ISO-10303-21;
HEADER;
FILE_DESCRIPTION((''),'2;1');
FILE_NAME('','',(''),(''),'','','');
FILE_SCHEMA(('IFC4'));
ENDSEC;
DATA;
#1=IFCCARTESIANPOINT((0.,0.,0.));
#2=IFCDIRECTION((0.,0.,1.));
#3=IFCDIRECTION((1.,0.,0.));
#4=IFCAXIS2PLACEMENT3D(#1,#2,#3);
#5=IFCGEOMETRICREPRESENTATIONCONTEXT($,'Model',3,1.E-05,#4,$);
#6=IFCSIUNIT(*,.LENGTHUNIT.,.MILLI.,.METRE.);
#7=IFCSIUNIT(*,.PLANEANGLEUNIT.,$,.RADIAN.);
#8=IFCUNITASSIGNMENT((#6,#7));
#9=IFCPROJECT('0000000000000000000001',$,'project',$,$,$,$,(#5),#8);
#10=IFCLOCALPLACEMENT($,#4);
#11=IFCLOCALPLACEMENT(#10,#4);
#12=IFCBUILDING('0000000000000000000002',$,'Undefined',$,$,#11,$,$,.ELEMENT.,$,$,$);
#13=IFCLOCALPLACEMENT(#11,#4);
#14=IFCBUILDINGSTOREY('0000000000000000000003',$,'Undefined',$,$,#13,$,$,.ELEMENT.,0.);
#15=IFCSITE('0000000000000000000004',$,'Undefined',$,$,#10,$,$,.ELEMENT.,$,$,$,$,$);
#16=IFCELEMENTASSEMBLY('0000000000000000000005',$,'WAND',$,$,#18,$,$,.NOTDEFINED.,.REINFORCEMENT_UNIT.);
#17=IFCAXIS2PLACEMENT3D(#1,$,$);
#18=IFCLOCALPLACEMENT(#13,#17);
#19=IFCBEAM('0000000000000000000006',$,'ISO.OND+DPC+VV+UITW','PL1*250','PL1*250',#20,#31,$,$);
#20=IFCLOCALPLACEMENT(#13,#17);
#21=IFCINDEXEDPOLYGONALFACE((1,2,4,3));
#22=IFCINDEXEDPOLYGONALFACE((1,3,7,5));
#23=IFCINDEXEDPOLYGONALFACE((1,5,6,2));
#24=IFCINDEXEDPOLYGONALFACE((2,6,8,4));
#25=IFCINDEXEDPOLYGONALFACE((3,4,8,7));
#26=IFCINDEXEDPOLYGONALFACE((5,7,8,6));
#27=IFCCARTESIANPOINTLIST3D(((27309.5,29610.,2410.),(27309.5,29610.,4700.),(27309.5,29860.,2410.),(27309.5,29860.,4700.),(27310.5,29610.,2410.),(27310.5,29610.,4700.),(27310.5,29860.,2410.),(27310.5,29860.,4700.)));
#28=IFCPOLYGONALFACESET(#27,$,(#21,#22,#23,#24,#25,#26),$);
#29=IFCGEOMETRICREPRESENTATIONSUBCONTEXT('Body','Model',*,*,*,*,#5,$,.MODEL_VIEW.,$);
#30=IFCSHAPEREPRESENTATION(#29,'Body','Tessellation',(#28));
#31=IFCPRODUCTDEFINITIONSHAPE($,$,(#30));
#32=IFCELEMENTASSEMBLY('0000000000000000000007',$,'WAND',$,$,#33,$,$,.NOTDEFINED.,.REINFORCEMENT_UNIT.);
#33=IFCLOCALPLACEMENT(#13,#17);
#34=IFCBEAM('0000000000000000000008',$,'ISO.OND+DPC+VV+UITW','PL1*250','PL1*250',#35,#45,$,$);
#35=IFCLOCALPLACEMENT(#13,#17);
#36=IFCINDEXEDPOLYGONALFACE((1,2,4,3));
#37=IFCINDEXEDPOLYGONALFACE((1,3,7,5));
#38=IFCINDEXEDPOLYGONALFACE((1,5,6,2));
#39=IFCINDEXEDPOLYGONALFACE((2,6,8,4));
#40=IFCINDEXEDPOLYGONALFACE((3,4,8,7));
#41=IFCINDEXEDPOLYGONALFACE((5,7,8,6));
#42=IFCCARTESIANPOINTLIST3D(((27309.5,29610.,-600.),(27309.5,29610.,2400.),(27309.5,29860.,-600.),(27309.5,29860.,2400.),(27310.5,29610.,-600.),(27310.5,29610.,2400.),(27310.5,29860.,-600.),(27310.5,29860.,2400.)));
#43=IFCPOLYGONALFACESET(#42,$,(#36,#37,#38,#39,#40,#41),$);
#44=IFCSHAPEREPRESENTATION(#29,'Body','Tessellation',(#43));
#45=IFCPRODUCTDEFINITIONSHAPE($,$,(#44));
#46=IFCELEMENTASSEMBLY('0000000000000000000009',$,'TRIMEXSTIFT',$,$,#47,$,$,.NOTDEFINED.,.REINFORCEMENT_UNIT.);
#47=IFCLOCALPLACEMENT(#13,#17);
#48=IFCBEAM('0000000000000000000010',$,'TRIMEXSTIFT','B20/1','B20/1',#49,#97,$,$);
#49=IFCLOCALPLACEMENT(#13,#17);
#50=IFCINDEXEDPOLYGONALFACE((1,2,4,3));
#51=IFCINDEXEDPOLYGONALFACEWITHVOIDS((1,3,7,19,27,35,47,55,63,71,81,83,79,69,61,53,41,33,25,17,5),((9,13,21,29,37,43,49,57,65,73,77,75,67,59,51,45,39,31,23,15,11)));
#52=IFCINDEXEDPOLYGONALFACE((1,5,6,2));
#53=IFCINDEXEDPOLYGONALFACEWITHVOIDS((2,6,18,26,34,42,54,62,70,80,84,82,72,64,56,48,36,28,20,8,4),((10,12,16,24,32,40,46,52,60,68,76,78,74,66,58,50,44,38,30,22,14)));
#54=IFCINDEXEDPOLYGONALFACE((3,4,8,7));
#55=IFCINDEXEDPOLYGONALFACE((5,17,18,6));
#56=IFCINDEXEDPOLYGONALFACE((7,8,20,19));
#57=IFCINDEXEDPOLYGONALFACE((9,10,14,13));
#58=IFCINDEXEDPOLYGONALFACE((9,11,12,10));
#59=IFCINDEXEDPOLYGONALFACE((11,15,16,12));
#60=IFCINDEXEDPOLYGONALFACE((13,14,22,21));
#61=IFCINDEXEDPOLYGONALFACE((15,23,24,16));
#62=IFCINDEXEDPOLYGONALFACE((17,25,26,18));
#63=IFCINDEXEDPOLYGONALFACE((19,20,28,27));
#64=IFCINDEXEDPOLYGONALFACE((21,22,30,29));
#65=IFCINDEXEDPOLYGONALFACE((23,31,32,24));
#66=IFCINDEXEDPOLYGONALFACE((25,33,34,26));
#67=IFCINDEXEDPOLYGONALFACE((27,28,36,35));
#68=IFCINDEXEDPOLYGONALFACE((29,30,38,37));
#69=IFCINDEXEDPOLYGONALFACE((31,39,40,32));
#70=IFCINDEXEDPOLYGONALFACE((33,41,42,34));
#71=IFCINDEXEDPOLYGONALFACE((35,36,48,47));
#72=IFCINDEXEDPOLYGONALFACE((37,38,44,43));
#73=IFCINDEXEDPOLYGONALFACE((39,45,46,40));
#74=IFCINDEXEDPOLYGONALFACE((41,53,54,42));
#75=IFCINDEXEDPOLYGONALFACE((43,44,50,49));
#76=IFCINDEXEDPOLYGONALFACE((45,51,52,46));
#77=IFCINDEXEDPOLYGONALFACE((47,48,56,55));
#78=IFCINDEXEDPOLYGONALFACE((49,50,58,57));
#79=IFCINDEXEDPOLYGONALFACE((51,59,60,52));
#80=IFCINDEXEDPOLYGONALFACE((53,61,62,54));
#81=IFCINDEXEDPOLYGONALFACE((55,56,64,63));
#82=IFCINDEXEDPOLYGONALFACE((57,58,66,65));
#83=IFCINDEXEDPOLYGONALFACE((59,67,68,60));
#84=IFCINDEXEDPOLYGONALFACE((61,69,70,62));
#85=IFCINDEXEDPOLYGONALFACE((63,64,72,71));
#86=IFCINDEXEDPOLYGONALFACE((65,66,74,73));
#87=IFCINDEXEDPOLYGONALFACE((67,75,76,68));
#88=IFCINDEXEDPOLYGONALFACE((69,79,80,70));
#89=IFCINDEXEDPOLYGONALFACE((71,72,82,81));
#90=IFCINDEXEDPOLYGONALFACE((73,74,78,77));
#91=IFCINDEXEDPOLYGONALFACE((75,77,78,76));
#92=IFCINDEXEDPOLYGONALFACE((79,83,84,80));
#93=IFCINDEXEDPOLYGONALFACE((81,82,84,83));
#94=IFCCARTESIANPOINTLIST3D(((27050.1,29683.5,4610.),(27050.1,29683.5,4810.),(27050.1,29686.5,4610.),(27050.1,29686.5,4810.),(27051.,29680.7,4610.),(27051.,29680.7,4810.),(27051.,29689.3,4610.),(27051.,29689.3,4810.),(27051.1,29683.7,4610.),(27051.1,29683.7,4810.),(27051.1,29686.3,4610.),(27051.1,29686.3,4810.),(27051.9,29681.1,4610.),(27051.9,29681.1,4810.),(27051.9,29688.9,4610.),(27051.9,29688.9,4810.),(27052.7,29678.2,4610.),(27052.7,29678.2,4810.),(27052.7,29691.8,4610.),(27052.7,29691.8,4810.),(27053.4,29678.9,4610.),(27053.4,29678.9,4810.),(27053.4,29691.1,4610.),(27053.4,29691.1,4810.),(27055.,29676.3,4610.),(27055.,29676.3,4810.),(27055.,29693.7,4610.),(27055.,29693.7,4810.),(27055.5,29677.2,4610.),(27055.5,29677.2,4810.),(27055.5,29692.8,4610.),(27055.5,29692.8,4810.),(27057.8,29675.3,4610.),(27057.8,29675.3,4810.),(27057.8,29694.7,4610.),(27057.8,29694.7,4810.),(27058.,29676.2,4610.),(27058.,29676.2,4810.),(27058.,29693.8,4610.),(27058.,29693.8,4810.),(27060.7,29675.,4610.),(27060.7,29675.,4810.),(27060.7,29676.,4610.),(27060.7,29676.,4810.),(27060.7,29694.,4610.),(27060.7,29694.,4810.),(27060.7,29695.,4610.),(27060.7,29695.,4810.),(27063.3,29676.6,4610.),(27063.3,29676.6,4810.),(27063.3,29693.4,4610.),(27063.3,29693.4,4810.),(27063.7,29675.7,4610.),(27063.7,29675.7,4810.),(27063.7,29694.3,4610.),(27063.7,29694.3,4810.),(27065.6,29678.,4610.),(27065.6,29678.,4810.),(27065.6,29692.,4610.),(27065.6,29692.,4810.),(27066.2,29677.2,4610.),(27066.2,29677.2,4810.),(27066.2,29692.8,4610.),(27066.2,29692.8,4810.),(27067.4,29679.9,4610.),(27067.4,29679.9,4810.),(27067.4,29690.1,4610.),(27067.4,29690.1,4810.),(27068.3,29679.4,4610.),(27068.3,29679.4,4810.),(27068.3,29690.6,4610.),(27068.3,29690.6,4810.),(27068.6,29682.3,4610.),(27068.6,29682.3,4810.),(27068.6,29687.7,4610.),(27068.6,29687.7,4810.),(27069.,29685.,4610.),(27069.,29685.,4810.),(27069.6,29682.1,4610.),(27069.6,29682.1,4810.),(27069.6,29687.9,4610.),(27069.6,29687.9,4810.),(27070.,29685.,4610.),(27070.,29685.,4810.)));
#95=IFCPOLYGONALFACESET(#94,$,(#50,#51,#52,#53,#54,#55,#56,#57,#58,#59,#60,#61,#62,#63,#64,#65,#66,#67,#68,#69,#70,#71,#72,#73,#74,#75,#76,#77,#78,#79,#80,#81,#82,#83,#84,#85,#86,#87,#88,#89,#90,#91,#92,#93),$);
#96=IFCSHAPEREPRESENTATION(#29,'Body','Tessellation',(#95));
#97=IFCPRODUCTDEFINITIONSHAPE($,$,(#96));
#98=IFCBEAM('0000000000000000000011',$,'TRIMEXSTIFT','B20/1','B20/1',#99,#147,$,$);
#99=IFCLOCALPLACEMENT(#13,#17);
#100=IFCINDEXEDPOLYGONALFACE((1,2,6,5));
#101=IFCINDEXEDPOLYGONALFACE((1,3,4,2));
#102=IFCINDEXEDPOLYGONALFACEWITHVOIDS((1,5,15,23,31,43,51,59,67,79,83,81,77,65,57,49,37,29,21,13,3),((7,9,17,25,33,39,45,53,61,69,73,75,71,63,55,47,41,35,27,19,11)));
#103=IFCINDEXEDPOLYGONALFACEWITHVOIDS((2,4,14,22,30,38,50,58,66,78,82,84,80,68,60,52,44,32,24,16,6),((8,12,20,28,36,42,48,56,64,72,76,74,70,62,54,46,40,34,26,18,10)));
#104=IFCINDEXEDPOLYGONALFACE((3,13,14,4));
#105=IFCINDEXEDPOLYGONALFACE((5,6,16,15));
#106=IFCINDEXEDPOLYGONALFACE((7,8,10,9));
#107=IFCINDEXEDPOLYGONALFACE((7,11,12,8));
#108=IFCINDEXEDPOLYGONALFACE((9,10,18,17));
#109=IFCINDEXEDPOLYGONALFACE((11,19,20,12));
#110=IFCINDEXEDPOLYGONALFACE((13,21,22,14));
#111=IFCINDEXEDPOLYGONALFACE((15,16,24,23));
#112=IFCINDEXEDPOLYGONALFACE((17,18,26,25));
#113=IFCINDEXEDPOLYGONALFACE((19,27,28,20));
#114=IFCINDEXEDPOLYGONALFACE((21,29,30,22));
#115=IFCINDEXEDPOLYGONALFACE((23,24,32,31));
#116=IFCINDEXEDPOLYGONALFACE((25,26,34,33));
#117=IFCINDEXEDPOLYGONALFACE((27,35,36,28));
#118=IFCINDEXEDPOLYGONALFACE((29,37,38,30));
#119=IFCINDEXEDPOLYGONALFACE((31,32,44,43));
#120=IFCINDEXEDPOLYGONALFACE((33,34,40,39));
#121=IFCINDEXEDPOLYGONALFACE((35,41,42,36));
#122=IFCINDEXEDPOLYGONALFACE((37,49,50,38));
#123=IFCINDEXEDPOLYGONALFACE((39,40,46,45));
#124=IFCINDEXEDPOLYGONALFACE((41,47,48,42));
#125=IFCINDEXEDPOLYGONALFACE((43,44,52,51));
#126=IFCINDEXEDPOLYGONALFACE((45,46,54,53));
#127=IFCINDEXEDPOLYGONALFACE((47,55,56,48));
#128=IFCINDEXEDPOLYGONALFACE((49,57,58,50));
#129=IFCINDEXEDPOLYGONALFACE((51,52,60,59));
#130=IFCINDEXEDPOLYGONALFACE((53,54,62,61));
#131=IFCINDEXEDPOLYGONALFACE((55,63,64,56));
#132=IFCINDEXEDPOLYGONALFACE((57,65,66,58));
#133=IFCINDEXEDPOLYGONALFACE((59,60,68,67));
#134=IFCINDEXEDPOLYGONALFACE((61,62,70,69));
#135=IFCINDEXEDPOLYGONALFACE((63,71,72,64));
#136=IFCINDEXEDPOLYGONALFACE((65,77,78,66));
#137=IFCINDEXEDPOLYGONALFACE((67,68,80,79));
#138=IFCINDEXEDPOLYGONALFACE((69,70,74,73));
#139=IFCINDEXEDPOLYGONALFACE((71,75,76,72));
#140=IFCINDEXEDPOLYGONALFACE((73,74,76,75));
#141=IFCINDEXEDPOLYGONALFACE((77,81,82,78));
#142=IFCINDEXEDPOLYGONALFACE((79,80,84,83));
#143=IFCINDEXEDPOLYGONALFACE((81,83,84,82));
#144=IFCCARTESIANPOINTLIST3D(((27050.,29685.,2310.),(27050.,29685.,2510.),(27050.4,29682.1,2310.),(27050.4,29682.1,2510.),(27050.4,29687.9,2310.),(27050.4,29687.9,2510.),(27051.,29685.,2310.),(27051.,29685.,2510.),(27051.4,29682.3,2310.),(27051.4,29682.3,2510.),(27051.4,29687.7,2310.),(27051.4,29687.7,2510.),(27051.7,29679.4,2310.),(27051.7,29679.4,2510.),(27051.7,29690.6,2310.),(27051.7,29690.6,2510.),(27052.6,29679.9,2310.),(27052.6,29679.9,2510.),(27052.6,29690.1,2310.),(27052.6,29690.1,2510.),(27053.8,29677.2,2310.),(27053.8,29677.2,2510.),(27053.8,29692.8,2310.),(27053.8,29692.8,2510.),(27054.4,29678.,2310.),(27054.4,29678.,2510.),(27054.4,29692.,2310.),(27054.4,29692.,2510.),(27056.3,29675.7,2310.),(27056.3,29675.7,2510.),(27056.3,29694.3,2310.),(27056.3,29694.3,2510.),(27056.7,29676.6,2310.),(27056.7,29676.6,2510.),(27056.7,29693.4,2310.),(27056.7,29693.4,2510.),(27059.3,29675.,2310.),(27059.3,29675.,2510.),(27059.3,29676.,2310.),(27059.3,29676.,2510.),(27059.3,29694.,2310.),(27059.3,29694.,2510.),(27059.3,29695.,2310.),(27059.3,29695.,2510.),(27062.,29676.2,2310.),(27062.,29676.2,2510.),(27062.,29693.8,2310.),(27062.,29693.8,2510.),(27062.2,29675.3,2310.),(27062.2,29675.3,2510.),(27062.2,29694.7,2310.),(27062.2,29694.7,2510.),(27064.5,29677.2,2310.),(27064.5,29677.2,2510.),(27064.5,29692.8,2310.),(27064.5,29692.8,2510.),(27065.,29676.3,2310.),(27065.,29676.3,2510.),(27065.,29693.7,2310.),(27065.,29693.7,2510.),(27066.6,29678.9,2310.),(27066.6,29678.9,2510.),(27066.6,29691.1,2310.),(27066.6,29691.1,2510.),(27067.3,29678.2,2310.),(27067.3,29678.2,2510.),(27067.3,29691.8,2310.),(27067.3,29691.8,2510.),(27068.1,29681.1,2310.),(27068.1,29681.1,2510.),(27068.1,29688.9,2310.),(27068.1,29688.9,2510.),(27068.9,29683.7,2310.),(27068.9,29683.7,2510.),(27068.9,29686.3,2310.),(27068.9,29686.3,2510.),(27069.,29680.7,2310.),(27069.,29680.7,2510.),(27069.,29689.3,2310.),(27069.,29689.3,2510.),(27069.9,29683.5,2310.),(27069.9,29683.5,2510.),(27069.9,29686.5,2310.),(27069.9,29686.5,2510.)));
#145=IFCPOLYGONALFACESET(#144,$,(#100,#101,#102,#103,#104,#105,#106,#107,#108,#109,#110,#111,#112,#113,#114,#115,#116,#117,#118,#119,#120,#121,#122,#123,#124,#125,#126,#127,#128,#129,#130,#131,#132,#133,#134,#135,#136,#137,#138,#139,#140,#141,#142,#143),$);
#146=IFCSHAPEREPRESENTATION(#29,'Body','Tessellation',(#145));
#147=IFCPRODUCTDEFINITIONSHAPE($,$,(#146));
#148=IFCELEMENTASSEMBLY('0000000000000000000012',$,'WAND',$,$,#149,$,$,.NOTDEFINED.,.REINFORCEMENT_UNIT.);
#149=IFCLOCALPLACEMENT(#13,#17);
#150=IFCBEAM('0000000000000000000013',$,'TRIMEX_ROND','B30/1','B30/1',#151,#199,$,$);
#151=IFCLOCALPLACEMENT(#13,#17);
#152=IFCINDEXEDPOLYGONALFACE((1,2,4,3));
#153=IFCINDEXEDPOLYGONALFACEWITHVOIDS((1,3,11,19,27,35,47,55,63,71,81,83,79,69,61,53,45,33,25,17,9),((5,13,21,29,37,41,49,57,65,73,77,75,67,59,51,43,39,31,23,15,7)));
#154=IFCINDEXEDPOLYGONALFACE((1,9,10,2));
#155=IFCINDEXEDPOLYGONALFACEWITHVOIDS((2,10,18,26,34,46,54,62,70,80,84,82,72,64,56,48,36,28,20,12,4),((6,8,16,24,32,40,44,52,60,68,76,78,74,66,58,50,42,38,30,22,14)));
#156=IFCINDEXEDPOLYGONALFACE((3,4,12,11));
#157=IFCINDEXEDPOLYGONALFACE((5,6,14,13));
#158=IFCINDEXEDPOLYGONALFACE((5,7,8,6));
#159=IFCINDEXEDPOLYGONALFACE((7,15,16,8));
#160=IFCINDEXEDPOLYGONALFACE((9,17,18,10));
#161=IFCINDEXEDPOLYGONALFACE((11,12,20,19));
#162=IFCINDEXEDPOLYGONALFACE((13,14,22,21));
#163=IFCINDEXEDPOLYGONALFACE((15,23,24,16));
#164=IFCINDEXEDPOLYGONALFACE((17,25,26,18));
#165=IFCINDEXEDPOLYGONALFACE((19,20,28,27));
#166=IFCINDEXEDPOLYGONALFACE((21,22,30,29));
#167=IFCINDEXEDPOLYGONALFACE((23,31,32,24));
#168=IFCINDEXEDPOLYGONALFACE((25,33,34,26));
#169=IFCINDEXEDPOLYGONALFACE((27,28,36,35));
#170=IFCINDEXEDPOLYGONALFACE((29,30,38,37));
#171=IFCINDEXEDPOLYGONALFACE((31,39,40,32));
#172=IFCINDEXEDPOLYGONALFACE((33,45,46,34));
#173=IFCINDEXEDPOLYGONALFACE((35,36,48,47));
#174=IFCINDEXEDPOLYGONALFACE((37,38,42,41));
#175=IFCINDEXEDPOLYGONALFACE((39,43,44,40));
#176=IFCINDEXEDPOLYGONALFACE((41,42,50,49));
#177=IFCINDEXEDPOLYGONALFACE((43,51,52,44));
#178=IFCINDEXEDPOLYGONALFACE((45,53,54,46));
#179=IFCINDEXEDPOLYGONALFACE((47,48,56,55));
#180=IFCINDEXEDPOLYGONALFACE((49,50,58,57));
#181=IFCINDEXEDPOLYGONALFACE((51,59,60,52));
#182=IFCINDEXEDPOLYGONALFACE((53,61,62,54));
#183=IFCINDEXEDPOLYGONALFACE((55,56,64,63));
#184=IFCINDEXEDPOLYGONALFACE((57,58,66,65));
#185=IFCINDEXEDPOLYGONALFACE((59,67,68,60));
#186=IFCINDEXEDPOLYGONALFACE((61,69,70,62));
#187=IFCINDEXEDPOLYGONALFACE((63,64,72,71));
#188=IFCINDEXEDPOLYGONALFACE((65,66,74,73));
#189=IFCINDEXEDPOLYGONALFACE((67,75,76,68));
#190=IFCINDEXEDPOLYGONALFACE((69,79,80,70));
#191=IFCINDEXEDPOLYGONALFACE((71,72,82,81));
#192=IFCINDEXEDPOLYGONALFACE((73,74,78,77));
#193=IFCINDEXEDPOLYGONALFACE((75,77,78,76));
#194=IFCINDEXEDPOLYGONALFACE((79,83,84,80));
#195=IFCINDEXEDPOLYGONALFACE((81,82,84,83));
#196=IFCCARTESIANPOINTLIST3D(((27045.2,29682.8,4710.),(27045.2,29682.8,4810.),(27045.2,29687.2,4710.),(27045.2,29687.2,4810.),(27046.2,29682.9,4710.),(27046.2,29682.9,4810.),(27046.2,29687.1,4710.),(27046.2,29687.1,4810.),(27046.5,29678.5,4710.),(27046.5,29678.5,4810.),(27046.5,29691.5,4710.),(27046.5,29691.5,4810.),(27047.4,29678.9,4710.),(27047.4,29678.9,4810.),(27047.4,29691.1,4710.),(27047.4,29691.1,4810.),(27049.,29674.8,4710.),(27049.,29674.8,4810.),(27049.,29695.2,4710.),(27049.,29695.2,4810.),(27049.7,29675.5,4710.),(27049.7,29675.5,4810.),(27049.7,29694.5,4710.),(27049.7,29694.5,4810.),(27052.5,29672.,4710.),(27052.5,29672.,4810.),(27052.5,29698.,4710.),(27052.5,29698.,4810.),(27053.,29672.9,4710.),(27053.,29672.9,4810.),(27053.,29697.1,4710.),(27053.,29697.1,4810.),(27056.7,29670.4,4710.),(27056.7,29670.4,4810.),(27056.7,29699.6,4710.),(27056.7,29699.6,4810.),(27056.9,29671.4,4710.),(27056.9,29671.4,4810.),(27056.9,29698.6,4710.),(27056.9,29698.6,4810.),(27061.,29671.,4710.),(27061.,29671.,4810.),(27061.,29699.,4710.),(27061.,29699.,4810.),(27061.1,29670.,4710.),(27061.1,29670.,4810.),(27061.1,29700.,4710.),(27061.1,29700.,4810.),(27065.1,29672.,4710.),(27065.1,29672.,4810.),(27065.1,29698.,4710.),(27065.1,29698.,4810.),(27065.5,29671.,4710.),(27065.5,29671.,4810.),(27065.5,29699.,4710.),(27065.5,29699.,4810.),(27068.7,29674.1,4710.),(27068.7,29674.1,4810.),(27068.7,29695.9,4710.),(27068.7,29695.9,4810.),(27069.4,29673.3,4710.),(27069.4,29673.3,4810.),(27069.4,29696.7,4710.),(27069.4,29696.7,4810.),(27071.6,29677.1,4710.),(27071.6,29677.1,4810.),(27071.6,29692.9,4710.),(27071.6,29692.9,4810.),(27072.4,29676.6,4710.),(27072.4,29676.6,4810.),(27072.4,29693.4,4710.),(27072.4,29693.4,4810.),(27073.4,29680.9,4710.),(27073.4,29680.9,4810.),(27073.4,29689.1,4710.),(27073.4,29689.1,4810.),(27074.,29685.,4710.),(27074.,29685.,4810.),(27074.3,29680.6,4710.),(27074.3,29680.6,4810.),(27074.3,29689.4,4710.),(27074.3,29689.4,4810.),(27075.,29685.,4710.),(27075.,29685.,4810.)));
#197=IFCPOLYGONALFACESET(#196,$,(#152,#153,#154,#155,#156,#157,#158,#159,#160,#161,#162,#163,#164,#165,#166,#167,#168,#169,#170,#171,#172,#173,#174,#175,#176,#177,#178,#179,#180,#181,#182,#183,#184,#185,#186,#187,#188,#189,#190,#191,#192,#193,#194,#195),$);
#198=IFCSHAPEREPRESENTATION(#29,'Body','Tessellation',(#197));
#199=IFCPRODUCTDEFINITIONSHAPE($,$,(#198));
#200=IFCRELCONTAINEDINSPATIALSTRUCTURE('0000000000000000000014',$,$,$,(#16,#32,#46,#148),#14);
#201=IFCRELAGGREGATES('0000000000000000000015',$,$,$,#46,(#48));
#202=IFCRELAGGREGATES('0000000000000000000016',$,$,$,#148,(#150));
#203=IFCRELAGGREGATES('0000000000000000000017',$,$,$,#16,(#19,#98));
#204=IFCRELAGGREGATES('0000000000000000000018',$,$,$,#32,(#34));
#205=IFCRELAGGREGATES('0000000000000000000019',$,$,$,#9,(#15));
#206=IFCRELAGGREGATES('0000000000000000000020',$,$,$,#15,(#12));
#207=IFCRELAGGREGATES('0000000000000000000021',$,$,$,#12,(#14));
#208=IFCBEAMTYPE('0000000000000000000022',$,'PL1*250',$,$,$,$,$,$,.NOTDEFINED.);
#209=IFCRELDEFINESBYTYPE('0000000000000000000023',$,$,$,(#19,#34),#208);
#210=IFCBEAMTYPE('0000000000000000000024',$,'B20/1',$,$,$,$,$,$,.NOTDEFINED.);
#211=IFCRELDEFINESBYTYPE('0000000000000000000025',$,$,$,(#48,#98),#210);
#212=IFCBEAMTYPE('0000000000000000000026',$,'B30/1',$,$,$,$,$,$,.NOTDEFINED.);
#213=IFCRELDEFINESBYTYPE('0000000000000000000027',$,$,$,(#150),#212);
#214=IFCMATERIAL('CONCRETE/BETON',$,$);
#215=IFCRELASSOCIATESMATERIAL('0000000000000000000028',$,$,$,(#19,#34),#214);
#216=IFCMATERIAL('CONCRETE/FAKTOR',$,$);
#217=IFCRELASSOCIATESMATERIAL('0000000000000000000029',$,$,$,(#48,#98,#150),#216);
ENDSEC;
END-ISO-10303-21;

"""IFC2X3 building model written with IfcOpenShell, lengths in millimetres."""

from ifc_helpers import new_model, si_unit, frame, frame_2d, origin_with_axes, place, context, subcontext, project, spatial, rectangle, hollow_circle, extrude, material, type_object, element, aggregate, save


model = new_model("IFC2X3")

# Units and contexts
model_context = context("Model", 3, precision=1e-05, world=origin_with_axes())
body_context = subcontext(model_context, "Body", "Model", "MODEL_VIEW")
ifc_project = project(units=[si_unit("LENGTHUNIT", "METRE", prefix="MILLI"), si_unit("PLANEANGLEUNIT", "RADIAN")], contexts=[model_context])

# Site, building, storey
site_placement = place(None, origin_with_axes())
site = spatial("IfcSite", under=ifc_project, at=site_placement, Name="Undefined", CompositionType="ELEMENT")
building_placement = place(site_placement, origin_with_axes())
building = spatial("IfcBuilding", under=site, at=building_placement, Name="Undefined", CompositionType="ELEMENT")
storey_placement = place(building_placement, origin_with_axes())
storey = spatial("IfcBuildingStorey", under=building, at=storey_placement, Name="Undefined", CompositionType="ELEMENT", Elevation=0.0)

# Element assemblies, beams
assembly_1_placement = place(storey_placement, origin_with_axes())
assembly_1 = element("IfcElementAssembly", 1, at=assembly_1_placement, inside=storey, Name="WAND", AssemblyPlace="NOTDEFINED", PredefinedType="REINFORCEMENT_UNIT")
ifc_material_1 = material(Name="CONCRETE/BETON")
beam_type_1 = type_object("IfcBeamType", Name="PL1*250", PredefinedType="NOTDEFINED")
beam_1_placement = place(assembly_1_placement, frame((27310.0, 29735.0, 2410.0), z_axis=(0.0, 1.0, 0.0), x_axis=(0.0, 0.0, 1.0)))
beam_1 = element("IfcBeam", 2, at=beam_1_placement, type_object=beam_type_1, material=ifc_material_1, Name="ISO.OND+DPC+VV+UITW", Description="PL1*250", ObjectType="PL1*250", context=body_context, shape_type="SweptSolid", body=[
    extrude(rectangle(XDim=1.0, YDim=250.0, at=frame_2d((0.0, 0.0), x_axis=(1.0, 0.0))), frame((2290.0, 0.0, 0.0), z_axis=(-1.0, 0.0, 0.0), x_axis=(0.0, -1.0, 0.0)), (0.0, 0.0, 1.0), 2290.0),
])
assembly_2_placement = place(storey_placement, origin_with_axes())
assembly_2 = element("IfcElementAssembly", 3, at=assembly_2_placement, inside=storey, Name="WAND", AssemblyPlace="NOTDEFINED", PredefinedType="REINFORCEMENT_UNIT")
beam_2_placement = place(assembly_2_placement, frame((27310.0, 29735.0, -600.0), z_axis=(0.0, 1.0, 0.0), x_axis=(0.0, 0.0, 1.0)))
beam_2 = element("IfcBeam", 4, at=beam_2_placement, type_object=beam_type_1, material=ifc_material_1, Name="ISO.OND+DPC+VV+UITW", Description="PL1*250", ObjectType="PL1*250", context=body_context, shape_type="SweptSolid", body=[
    extrude(rectangle(XDim=1.0, YDim=250.0, at=frame_2d((0.0, 0.0), x_axis=(1.0, 0.0))), frame((3000.0, 0.0, 0.0), z_axis=(-1.0, 0.0, 0.0), x_axis=(0.0, -1.0, 0.0)), (0.0, 0.0, 1.0), 3000.0),
])
assembly_3_placement = place(storey_placement, origin_with_axes())
assembly_3 = element("IfcElementAssembly", 5, at=assembly_3_placement, inside=storey, Name="TRIMEXSTIFT", AssemblyPlace="NOTDEFINED", PredefinedType="REINFORCEMENT_UNIT")
ifc_material_2 = material(Name="CONCRETE/FAKTOR")
beam_type_2 = type_object("IfcBeamType", Name="B20/1", PredefinedType="NOTDEFINED")
beam_3_placement = place(assembly_3_placement, frame((27060.0, 29685.0, 4610.0), z_axis=(0.0, -1.0, 0.0), x_axis=(0.0, 0.0, 1.0)))
beam_3 = element("IfcBeam", 6, at=beam_3_placement, type_object=beam_type_2, material=ifc_material_2, Name="TRIMEXSTIFT", Description="B20/1", ObjectType="B20/1", context=body_context, shape_type="SweptSolid", body=[
    extrude(hollow_circle(Radius=10.0, WallThickness=1.0, at=frame_2d((0.0, 0.0), x_axis=(1.0, 0.0))), frame((200.0, 0.0, 0.0), z_axis=(-1.0, 0.0, 0.0), x_axis=(0.0, -1.0, 0.0)), (0.0, 0.0, 1.0), 200.0),
])
aggregate(assembly_3, [beam_3])

# Beam
beam_4_placement = place(assembly_1_placement, frame((27060.0, 29685.0, 2310.0), z_axis=(0.0, 1.0, 0.0), x_axis=(0.0, 0.0, 1.0)))
beam_4 = element("IfcBeam", 7, at=beam_4_placement, type_object=beam_type_2, material=ifc_material_2, Name="TRIMEXSTIFT", Description="B20/1", ObjectType="B20/1", context=body_context, shape_type="SweptSolid", body=[
    extrude(hollow_circle(Radius=10.0, WallThickness=1.0, at=frame_2d((0.0, 0.0), x_axis=(1.0, 0.0))), frame((200.0, 0.0, 0.0), z_axis=(-1.0, 0.0, 0.0), x_axis=(0.0, -1.0, 0.0)), (0.0, 0.0, 1.0), 200.0),
])

# Element assembly, beam
assembly_4_placement = place(storey_placement, origin_with_axes())
assembly_4 = element("IfcElementAssembly", 8, at=assembly_4_placement, inside=storey, Name="WAND", AssemblyPlace="NOTDEFINED", PredefinedType="REINFORCEMENT_UNIT")
beam_type_3 = type_object("IfcBeamType", Name="B30/1", PredefinedType="NOTDEFINED")
beam_5_placement = place(assembly_4_placement, frame((27060.0, 29685.0, 4710.0), z_axis=(0.0, -1.0, 0.0), x_axis=(0.0, 0.0, 1.0)))
beam_5 = element("IfcBeam", 9, at=beam_5_placement, type_object=beam_type_3, material=ifc_material_2, Name="TRIMEX_ROND", Description="B30/1", ObjectType="B30/1", context=body_context, shape_type="SweptSolid", body=[
    extrude(hollow_circle(Radius=15.0, WallThickness=1.0, at=frame_2d((0.0, 0.0), x_axis=(1.0, 0.0))), frame((100.0, 0.0, 0.0), z_axis=(-1.0, 0.0, 0.0), x_axis=(0.0, -1.0, 0.0)), (0.0, 0.0, 1.0), 100.0),
])
aggregate(assembly_4, [beam_5])

aggregate(assembly_1, [beam_1, beam_4])
aggregate(assembly_2, [beam_2])

save(model, "model.ifc")
